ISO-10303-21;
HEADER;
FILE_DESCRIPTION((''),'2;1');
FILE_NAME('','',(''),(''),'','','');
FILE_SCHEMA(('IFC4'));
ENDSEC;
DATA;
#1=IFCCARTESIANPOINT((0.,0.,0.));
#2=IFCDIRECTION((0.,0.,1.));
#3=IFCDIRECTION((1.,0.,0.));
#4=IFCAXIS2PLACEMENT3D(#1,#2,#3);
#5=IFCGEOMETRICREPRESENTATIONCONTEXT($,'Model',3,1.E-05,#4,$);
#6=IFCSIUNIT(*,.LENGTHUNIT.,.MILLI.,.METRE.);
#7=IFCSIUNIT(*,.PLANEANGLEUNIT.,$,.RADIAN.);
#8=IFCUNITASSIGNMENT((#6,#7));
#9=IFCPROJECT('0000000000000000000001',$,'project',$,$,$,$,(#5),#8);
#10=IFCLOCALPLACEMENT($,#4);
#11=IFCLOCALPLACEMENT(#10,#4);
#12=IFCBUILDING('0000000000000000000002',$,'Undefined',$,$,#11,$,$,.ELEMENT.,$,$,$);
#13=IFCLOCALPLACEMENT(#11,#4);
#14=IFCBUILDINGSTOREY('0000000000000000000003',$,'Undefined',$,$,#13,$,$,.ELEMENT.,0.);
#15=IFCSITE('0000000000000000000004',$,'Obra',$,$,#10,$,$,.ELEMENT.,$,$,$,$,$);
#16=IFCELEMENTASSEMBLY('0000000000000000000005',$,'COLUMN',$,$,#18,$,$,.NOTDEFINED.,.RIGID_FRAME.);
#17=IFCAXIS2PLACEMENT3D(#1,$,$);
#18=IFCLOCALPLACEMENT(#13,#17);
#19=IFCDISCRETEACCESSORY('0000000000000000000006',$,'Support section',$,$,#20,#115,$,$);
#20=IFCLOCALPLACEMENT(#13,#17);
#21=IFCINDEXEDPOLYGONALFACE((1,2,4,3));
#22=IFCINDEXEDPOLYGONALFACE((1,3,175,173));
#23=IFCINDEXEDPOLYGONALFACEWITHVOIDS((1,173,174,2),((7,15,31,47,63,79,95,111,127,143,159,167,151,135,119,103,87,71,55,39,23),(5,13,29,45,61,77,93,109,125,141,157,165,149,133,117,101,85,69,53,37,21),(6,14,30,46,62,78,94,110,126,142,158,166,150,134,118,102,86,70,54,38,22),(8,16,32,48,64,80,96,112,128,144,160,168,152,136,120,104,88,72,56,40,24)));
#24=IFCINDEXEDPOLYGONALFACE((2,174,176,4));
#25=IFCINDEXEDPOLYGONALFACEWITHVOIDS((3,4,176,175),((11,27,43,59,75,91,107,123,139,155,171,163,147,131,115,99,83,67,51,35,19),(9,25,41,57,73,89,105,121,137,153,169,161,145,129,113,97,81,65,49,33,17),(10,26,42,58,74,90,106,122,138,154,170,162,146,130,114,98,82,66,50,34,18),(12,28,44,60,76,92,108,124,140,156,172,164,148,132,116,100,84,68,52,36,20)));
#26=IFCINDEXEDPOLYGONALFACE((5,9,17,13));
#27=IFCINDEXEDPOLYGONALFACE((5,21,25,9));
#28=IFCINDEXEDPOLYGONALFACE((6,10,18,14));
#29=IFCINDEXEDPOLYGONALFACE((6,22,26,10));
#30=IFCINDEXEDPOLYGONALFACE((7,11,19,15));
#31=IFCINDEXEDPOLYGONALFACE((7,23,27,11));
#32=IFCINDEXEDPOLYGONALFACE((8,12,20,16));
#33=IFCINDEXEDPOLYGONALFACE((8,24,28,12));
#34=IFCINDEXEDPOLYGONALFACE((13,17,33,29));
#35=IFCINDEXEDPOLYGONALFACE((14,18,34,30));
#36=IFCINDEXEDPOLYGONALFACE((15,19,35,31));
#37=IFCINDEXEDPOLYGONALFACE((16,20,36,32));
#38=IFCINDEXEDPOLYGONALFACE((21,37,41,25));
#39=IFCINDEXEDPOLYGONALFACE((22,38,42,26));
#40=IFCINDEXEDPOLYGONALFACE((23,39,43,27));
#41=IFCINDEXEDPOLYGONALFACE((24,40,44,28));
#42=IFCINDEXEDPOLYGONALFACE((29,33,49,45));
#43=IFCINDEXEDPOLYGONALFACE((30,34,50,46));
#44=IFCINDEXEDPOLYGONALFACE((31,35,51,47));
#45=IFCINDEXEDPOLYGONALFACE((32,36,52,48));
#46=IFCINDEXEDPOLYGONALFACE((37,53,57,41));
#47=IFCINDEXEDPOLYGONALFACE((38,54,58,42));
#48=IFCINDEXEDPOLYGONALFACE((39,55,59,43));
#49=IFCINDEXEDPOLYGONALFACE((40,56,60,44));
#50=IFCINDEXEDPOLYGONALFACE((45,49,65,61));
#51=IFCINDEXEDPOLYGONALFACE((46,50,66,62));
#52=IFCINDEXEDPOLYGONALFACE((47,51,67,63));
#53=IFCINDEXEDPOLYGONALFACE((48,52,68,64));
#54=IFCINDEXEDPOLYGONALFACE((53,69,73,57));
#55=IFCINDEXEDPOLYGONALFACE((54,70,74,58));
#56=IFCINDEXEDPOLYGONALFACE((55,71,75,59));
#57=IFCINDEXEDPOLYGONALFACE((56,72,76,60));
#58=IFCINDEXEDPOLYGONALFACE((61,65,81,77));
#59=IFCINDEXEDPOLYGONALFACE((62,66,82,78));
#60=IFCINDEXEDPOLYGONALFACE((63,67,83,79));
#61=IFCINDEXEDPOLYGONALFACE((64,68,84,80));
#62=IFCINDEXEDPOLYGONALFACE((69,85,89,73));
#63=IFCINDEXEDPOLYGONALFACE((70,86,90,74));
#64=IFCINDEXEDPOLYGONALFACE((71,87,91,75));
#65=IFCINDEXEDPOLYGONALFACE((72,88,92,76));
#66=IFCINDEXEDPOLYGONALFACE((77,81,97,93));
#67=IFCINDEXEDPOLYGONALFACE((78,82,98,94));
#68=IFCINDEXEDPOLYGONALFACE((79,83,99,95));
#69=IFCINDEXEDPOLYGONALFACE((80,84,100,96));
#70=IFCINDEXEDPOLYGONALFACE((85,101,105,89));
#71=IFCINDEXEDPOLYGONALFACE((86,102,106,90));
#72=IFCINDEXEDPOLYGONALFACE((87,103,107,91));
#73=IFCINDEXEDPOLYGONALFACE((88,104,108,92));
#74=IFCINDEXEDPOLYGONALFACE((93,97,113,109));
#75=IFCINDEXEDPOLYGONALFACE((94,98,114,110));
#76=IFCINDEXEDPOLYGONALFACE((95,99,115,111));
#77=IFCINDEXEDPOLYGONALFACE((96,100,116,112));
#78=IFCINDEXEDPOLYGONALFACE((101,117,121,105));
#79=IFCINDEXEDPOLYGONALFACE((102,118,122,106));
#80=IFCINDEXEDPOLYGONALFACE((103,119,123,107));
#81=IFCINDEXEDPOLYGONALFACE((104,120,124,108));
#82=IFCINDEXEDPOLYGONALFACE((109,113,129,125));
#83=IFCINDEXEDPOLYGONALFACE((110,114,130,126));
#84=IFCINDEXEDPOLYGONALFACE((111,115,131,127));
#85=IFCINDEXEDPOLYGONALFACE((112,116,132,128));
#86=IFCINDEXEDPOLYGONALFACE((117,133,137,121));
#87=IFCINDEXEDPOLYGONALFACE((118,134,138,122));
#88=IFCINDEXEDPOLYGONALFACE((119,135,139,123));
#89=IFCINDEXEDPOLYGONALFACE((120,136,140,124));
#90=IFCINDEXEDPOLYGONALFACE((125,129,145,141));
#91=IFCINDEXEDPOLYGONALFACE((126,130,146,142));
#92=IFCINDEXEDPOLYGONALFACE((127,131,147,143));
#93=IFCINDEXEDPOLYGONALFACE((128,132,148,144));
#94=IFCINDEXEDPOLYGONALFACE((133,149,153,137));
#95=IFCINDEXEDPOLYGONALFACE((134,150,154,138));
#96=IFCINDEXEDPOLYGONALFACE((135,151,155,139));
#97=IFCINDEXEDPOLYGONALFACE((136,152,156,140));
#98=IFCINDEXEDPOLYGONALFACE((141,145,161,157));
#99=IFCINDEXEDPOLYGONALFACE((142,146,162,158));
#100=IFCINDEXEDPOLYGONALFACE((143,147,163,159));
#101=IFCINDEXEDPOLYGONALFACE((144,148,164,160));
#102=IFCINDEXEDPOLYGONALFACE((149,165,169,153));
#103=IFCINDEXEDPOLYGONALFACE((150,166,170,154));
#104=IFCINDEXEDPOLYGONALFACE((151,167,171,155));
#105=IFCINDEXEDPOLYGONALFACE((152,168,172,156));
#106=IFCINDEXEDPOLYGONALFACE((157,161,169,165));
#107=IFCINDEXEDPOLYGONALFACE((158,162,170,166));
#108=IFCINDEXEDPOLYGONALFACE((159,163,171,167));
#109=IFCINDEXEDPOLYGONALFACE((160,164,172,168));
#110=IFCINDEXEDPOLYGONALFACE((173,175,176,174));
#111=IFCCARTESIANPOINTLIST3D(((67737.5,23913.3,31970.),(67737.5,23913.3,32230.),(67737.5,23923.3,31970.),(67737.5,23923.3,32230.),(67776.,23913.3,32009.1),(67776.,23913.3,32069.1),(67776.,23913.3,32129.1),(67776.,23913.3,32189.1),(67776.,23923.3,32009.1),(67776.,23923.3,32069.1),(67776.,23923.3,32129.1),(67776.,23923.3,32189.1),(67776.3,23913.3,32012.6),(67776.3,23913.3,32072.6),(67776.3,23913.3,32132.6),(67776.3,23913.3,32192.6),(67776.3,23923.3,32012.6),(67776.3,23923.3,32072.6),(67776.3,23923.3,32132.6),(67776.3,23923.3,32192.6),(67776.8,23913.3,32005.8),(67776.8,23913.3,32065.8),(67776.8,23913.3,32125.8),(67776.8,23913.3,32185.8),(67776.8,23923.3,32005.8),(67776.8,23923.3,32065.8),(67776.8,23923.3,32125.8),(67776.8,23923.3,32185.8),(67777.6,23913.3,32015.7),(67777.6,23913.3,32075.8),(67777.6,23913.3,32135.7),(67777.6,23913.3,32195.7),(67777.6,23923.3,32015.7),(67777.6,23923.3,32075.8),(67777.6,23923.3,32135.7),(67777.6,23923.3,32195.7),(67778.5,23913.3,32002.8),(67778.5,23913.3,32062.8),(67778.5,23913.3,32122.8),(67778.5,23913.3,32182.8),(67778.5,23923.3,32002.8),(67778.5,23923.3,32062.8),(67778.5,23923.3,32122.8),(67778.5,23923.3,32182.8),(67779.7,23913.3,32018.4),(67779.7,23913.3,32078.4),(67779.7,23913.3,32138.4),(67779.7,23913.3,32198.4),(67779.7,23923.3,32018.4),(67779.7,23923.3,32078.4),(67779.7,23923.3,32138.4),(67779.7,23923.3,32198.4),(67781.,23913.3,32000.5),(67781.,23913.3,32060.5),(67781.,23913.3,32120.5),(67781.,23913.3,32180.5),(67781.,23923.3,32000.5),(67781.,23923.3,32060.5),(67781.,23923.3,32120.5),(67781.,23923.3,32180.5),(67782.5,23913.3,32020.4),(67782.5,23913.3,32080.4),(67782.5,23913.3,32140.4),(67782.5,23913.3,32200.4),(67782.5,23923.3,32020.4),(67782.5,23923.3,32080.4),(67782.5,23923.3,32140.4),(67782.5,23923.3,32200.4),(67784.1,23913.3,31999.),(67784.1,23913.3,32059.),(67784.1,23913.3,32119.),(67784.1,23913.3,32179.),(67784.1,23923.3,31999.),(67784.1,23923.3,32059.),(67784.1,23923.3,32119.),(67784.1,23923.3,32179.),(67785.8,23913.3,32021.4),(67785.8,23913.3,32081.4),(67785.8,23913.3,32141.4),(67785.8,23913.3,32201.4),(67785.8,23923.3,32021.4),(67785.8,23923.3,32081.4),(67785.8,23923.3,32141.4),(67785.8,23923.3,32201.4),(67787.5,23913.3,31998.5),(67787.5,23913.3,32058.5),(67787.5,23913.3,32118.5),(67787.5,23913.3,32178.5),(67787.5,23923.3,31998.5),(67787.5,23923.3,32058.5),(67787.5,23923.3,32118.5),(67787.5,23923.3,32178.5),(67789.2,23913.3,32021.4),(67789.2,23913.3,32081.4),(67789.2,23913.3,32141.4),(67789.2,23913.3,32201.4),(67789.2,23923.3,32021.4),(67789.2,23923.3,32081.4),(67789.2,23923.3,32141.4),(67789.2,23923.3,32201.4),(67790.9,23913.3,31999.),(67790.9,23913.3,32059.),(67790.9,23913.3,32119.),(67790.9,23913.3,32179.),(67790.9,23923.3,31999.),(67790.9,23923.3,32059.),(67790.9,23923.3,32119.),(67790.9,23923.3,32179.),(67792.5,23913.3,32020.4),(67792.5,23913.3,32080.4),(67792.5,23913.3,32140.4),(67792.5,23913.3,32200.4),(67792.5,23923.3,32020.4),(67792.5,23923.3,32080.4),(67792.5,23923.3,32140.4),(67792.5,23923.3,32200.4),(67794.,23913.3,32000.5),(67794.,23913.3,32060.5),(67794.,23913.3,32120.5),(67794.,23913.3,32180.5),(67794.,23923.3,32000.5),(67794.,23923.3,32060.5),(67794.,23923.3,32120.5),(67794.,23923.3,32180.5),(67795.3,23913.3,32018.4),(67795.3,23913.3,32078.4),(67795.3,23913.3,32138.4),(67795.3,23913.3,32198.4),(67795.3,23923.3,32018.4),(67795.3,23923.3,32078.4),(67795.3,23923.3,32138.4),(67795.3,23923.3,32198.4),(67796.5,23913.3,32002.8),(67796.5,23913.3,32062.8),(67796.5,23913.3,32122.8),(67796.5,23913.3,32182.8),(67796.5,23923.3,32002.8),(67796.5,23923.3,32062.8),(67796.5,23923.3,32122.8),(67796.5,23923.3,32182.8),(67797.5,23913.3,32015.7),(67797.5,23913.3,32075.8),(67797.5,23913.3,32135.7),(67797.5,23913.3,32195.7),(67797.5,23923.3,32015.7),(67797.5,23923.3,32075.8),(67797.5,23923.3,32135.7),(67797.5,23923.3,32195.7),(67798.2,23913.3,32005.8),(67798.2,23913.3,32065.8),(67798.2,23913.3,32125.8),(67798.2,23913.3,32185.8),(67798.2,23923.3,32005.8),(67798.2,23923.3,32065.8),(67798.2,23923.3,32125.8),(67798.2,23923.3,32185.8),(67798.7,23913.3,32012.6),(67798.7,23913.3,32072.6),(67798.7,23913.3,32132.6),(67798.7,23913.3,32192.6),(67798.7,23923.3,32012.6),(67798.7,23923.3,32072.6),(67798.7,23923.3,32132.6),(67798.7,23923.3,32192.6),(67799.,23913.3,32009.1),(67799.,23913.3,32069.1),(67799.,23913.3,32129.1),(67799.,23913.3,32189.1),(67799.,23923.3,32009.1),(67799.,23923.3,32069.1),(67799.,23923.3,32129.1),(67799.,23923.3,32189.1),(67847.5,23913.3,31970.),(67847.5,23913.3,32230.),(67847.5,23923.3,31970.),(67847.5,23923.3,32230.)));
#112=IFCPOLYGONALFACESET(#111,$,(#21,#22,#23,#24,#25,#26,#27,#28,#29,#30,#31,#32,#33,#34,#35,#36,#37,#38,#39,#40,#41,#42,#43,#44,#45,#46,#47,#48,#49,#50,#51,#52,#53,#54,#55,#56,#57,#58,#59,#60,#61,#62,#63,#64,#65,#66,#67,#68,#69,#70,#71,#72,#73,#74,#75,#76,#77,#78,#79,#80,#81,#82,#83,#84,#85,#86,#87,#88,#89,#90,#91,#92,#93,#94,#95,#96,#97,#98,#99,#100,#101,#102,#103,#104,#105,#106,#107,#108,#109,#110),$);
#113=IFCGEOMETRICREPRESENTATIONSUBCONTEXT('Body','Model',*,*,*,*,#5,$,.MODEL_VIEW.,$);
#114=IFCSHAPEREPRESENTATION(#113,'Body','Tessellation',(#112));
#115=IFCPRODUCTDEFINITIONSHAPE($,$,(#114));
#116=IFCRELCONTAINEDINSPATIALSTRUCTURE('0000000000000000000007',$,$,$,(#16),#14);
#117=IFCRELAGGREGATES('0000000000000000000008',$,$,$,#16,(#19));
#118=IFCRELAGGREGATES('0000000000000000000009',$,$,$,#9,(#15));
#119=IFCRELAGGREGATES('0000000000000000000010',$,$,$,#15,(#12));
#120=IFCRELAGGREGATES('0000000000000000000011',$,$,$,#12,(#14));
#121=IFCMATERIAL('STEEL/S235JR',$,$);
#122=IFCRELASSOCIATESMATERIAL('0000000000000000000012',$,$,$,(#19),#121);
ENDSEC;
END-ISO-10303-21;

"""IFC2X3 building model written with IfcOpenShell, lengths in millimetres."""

from ifc_helpers import new_model, si_unit, frame, origin_with_axes, origin_2d_with_axis, place, context, subcontext, project, spatial, rectangle, circle, extrude, source, transform, mapped, material, element, aggregate, save


model = new_model("IFC2X3")

# Units and contexts
model_context = context("Model", 3, precision=1e-05, world=origin_with_axes())
body_context = subcontext(model_context, "Body", "Model", "MODEL_VIEW")
ifc_project = project(units=[si_unit("LENGTHUNIT", "METRE", prefix="MILLI"), si_unit("PLANEANGLEUNIT", "RADIAN")], contexts=[model_context])

# Site, building, storey
site_placement = place(None, origin_with_axes())
site = spatial("IfcSite", under=ifc_project, at=site_placement, Name="Obra", CompositionType="ELEMENT")
building_placement = place(site_placement, origin_with_axes())
building = spatial("IfcBuilding", under=site, at=building_placement, Name="Undefined", CompositionType="ELEMENT")
storey_placement = place(building_placement, origin_with_axes())
storey = spatial("IfcBuildingStorey", under=building, at=storey_placement, Name="Undefined", CompositionType="ELEMENT", Elevation=0.0)

# Element assembly
assembly_1_placement = place(storey_placement, origin_with_axes())
assembly_1 = element("IfcElementAssembly", 1, at=assembly_1_placement, inside=storey, Name="COLUMN", AssemblyPlace="NOTDEFINED", PredefinedType="RIGID_FRAME")
ifc_material_1 = material(Name="STEEL/S235JR")

# Discrete accessory, opening
shared_shape_1 = source(origin_with_axes(), body_context, "Body", "SweptSolid", [
    extrude(circle(Radius=11.5, at=origin_2d_with_axis()), frame((0.0, -14.4, 0.0), z_axis=(0.0, 1.0, 0.0), x_axis=(1.0, 0.0, 0.0)), (0.0, 0.0, 1.0), 10.2),
])
discrete_accessory_1_placement = place(assembly_1_placement, frame((67792.5, 23918.3, 31970.0), z_axis=(0.0, 0.0, 1.0), x_axis=(1.0, 0.0, 0.0)))
discrete_accessory_1 = element("IfcDiscreteAccessory", 2, at=discrete_accessory_1_placement, material=ifc_material_1, Name="Support section", context=body_context, shape_type="SweptSolid", body=[
    extrude(rectangle(XDim=10.0, YDim=110.0, at=origin_2d_with_axis()), frame((0.0, 0.0, 260.0), z_axis=(0.0, 0.0, -1.0), x_axis=(0.0, 1.0, 0.0)), (0.0, 0.0, 1.0), 260.0),
])
opening_1_placement = place(assembly_1_placement, frame((67837.5, 23909.0, 32300.0), z_axis=(-1.0, 0.0, 0.0), x_axis=(0.0, 0.0, -1.0)))
element("IfcOpeningElement", 3, at=opening_1_placement, cuts=discrete_accessory_1, ObjectType="Opening", context=body_context, shape_type="MappedRepresentation", body=[
    mapped(shared_shape_1, transform((110.0, 0.0, 50.0))),
    mapped(shared_shape_1, transform((170.0, 0.0, 50.0))),
    mapped(shared_shape_1, transform((230.0, 0.0, 50.0))),
    mapped(shared_shape_1, transform((290.0, 0.0, 50.0))),
])
aggregate(assembly_1, [discrete_accessory_1])

save(model, "model.ifc")
